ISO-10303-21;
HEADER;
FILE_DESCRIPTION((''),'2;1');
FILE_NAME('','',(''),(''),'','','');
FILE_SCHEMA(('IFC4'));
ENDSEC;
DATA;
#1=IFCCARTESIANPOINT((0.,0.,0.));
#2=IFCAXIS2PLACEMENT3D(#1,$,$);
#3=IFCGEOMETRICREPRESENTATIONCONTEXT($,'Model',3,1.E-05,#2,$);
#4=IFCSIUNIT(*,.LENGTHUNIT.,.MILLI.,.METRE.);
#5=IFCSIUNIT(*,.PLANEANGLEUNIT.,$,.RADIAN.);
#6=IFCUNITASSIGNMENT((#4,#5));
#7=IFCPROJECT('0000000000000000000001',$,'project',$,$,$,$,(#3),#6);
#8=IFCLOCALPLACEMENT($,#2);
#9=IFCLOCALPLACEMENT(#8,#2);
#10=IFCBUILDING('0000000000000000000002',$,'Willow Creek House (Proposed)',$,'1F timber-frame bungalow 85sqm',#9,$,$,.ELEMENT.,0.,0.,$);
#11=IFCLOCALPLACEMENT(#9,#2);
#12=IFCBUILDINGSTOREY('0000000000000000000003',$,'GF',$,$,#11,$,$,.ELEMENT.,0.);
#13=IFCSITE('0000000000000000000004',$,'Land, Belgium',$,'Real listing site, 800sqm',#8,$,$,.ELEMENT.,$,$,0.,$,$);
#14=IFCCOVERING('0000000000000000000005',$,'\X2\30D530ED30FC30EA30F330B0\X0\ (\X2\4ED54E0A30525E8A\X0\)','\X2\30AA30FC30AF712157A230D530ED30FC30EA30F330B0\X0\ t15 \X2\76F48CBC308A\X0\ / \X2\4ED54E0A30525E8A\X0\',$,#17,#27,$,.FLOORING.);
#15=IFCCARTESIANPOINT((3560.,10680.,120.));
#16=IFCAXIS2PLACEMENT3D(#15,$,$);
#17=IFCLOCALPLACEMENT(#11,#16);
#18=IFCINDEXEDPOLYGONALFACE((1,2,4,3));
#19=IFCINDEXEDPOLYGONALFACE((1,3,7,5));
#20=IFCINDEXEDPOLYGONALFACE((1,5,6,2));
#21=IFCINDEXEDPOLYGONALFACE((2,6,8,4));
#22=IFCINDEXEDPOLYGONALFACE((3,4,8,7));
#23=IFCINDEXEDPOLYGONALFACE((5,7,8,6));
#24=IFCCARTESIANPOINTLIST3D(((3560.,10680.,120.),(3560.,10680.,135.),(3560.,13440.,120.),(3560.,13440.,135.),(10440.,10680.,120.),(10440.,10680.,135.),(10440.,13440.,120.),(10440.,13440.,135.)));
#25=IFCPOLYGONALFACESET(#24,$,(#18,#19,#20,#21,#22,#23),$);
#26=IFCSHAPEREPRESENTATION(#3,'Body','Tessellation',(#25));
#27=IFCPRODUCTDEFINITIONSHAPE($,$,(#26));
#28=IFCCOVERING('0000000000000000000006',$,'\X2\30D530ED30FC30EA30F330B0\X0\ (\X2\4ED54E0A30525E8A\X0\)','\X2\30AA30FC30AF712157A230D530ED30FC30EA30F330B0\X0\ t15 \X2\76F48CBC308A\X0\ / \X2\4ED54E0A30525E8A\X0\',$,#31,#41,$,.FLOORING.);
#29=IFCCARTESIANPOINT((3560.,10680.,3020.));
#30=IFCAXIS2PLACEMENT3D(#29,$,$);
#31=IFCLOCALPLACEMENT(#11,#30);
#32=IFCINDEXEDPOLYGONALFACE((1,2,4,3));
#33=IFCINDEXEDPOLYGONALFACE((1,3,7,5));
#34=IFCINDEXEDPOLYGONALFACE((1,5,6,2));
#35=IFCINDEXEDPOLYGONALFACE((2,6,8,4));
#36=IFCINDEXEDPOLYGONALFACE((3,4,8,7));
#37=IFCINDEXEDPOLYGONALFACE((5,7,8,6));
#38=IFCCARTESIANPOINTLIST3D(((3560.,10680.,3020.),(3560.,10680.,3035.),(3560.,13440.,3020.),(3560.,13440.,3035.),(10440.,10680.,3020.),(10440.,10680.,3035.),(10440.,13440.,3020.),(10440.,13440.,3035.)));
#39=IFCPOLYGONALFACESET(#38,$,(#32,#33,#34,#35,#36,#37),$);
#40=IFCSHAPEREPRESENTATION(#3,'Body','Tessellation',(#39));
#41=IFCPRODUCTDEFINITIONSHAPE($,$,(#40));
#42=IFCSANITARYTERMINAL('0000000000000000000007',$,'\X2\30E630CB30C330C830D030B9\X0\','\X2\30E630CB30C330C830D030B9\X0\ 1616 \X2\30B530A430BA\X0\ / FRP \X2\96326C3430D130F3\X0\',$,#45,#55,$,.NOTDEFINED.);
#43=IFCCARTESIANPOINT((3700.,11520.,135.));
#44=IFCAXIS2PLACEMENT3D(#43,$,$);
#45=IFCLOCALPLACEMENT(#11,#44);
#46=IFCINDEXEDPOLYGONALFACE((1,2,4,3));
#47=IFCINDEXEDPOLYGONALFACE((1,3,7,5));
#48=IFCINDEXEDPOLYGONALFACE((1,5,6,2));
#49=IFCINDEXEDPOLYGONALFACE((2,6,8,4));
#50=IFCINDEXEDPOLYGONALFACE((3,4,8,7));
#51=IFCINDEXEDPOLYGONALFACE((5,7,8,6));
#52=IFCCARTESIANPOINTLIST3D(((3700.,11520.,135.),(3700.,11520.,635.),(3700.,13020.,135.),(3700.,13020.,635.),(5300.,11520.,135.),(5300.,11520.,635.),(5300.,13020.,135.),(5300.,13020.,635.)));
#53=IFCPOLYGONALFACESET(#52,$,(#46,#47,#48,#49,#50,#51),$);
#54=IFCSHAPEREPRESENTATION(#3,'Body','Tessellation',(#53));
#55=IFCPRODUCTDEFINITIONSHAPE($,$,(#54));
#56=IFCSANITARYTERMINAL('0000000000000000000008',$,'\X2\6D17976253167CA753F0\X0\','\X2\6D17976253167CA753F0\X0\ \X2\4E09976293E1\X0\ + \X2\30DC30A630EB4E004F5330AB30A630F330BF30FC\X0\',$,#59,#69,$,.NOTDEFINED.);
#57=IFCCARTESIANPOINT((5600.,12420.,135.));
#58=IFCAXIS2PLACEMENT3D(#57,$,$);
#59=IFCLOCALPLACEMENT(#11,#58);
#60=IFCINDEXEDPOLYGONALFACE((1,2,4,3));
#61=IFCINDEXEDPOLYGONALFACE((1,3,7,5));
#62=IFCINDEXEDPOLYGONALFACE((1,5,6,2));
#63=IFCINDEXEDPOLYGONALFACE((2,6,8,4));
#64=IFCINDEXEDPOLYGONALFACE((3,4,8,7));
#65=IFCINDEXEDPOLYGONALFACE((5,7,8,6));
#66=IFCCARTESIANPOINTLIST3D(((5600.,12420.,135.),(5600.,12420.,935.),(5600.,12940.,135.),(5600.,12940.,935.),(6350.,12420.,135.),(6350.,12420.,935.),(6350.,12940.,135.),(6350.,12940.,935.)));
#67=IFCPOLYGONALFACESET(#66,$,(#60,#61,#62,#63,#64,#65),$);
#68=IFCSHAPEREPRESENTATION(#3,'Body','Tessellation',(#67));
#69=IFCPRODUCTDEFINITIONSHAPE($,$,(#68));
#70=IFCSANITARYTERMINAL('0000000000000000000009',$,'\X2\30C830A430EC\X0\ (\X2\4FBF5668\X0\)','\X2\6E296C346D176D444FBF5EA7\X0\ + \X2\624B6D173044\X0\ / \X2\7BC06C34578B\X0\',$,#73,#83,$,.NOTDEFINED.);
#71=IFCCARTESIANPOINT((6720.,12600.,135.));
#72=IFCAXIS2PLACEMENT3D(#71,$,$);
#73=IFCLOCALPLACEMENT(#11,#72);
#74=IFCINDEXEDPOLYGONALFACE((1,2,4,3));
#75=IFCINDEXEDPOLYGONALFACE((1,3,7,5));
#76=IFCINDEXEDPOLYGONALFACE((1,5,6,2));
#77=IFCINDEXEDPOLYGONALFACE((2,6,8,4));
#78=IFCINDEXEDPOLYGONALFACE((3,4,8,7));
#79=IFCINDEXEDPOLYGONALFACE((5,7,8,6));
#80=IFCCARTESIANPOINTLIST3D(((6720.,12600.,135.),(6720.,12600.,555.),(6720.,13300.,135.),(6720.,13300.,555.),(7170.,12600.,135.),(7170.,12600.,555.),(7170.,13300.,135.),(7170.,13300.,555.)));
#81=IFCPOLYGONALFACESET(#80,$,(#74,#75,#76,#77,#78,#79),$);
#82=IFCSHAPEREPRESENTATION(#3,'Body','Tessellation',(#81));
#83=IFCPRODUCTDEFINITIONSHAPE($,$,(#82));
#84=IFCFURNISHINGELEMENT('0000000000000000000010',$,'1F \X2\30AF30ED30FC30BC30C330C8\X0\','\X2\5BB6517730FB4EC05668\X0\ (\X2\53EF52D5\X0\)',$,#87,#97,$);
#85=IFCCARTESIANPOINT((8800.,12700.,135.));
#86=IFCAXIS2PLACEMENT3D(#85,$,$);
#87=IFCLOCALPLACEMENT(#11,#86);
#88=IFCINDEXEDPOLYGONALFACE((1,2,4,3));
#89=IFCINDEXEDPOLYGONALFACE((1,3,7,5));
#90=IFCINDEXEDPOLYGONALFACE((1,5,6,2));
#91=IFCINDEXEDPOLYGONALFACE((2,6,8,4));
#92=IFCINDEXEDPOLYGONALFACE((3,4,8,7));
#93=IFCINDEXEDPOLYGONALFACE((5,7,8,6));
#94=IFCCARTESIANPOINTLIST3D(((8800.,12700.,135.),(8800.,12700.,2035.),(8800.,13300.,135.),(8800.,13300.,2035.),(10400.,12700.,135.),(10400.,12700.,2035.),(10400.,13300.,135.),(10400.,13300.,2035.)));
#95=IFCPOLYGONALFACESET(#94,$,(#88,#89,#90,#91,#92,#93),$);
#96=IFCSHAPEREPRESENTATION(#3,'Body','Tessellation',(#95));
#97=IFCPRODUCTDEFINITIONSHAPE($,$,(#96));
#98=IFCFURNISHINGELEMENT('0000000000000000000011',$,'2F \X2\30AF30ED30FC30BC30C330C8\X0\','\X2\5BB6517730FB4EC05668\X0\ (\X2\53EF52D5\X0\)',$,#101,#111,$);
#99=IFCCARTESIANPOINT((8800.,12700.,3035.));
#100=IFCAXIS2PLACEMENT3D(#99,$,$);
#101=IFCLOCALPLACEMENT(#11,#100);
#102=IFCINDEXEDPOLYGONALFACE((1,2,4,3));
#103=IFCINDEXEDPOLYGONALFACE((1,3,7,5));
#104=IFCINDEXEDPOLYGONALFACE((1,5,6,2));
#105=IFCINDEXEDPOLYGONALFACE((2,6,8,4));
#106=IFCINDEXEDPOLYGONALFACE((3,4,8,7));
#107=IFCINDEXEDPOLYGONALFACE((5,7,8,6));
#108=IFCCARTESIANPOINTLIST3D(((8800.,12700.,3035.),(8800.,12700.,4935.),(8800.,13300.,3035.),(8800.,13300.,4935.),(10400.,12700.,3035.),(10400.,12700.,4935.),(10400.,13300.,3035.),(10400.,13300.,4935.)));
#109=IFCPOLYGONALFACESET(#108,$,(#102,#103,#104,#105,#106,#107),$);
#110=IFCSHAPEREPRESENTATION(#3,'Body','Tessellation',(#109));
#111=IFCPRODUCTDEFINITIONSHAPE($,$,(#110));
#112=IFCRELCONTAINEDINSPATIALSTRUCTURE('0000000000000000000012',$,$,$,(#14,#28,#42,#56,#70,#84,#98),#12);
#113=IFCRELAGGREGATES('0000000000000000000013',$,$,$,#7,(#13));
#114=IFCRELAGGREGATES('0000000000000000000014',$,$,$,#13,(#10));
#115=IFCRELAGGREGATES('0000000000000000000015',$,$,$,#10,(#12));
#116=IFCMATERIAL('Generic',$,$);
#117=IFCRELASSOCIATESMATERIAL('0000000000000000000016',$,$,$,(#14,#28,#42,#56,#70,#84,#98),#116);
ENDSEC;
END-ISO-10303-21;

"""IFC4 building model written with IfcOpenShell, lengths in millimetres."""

from ifc_helpers import new_model, si_unit, frame, frame_2d, origin, place, context, project, spatial, rectangle, extrude, material, element, save


model = new_model("IFC4")

# Units and contexts
model_context = context("Model", 3, precision=1e-05, world=origin())
ifc_project = project(units=[si_unit("LENGTHUNIT", "METRE", prefix="MILLI"), si_unit("PLANEANGLEUNIT", "RADIAN")], contexts=[model_context])

# Site, building, storey
site_placement = place(None, origin())
site = spatial("IfcSite", under=ifc_project, at=site_placement, Name="Land, Belgium", ObjectType="Real listing site, 800sqm", CompositionType="ELEMENT", RefElevation=0.0)
building_placement = place(site_placement, origin())
building = spatial("IfcBuilding", under=site, at=building_placement, Name="Willow Creek House (Proposed)", ObjectType="1F timber-frame bungalow 85sqm", CompositionType="ELEMENT", ElevationOfRefHeight=0.0, ElevationOfTerrain=0.0)
storey_placement = place(building_placement, origin())
storey = spatial("IfcBuildingStorey", under=building, at=storey_placement, Name="GF", CompositionType="ELEMENT", Elevation=0.0)

# Coverings
ifc_material_1 = material(Name="Generic")
covering_1_placement = place(storey_placement, frame((3560.0, 10680.0, 120.0)))
element("IfcCovering", 1, at=covering_1_placement, inside=storey, material=ifc_material_1, Name="フローリング (仕上げ床)", Description="オーク無垢フローリング t15 直貼り / 仕上げ床", PredefinedType="FLOORING", context=model_context, shape_type="SweptSolid", body=[
    extrude(rectangle(XDim=6880.0, YDim=2760.0, at=frame_2d((3440.0, 1380.0))), frame((3560.0, 10680.0, 120.0)), (0.0, 0.0, 1.0), 15.0),
])
covering_2_placement = place(storey_placement, frame((3560.0, 10680.0, 3020.0)))
element("IfcCovering", 2, at=covering_2_placement, inside=storey, material=ifc_material_1, Name="フローリング (仕上げ床)", Description="オーク無垢フローリング t15 直貼り / 仕上げ床", PredefinedType="FLOORING", context=model_context, shape_type="SweptSolid", body=[
    extrude(rectangle(XDim=6880.0, YDim=2760.0, at=frame_2d((3440.0, 1380.0))), frame((3560.0, 10680.0, 3020.0)), (0.0, 0.0, 1.0), 15.0),
])

# Sanitary terminals
sanitary_terminal_1_placement = place(storey_placement, frame((3700.0, 11520.0, 135.0)))
element("IfcSanitaryTerminal", 3, at=sanitary_terminal_1_placement, inside=storey, material=ifc_material_1, Name="ユニットバス", Description="ユニットバス 1616 サイズ / FRP 防水パン", PredefinedType="NOTDEFINED", context=model_context, shape_type="SweptSolid", body=[
    extrude(rectangle(XDim=1600.0, YDim=1500.0, at=frame_2d((800.0, 750.0))), frame((3700.0, 11520.0, 135.0)), (0.0, 0.0, 1.0), 500.0),
])
sanitary_terminal_2_placement = place(storey_placement, frame((5600.0, 12420.0, 135.0)))
element("IfcSanitaryTerminal", 4, at=sanitary_terminal_2_placement, inside=storey, material=ifc_material_1, Name="洗面化粧台", Description="洗面化粧台 三面鏡 + ボウル一体カウンター", PredefinedType="NOTDEFINED", context=model_context, shape_type="SweptSolid", body=[
    extrude(rectangle(XDim=750.0, YDim=520.0, at=frame_2d((375.0, 260.0))), frame((5600.0, 12420.0, 135.0)), (0.0, 0.0, 1.0), 800.0),
])
sanitary_terminal_3_placement = place(storey_placement, frame((6720.0, 12600.0, 135.0)))
element("IfcSanitaryTerminal", 5, at=sanitary_terminal_3_placement, inside=storey, material=ifc_material_1, Name="トイレ (便器)", Description="温水洗浄便座 + 手洗い / 節水型", PredefinedType="NOTDEFINED", context=model_context, shape_type="SweptSolid", body=[
    extrude(rectangle(XDim=450.0, YDim=700.0, at=frame_2d((225.0, 350.0))), frame((6720.0, 12600.0, 135.0)), (0.0, 0.0, 1.0), 420.0),
])

# Furnishing elements
furnishing_1_placement = place(storey_placement, frame((8800.0, 12700.0, 135.0)))
element("IfcFurnishingElement", 6, at=furnishing_1_placement, inside=storey, material=ifc_material_1, Name="1F クローゼット", Description="家具・什器 (可動)", context=model_context, shape_type="SweptSolid", body=[
    extrude(rectangle(XDim=1600.0, YDim=600.0, at=frame_2d((800.0, 300.0))), frame((8800.0, 12700.0, 135.0)), (0.0, 0.0, 1.0), 1900.0),
])
furnishing_2_placement = place(storey_placement, frame((8800.0, 12700.0, 3035.0)))
element("IfcFurnishingElement", 7, at=furnishing_2_placement, inside=storey, material=ifc_material_1, Name="2F クローゼット", Description="家具・什器 (可動)", context=model_context, shape_type="SweptSolid", body=[
    extrude(rectangle(XDim=1600.0, YDim=600.0, at=frame_2d((800.0, 300.0))), frame((8800.0, 12700.0, 3035.0)), (0.0, 0.0, 1.0), 1900.0),
])

save(model, "model.ifc")
